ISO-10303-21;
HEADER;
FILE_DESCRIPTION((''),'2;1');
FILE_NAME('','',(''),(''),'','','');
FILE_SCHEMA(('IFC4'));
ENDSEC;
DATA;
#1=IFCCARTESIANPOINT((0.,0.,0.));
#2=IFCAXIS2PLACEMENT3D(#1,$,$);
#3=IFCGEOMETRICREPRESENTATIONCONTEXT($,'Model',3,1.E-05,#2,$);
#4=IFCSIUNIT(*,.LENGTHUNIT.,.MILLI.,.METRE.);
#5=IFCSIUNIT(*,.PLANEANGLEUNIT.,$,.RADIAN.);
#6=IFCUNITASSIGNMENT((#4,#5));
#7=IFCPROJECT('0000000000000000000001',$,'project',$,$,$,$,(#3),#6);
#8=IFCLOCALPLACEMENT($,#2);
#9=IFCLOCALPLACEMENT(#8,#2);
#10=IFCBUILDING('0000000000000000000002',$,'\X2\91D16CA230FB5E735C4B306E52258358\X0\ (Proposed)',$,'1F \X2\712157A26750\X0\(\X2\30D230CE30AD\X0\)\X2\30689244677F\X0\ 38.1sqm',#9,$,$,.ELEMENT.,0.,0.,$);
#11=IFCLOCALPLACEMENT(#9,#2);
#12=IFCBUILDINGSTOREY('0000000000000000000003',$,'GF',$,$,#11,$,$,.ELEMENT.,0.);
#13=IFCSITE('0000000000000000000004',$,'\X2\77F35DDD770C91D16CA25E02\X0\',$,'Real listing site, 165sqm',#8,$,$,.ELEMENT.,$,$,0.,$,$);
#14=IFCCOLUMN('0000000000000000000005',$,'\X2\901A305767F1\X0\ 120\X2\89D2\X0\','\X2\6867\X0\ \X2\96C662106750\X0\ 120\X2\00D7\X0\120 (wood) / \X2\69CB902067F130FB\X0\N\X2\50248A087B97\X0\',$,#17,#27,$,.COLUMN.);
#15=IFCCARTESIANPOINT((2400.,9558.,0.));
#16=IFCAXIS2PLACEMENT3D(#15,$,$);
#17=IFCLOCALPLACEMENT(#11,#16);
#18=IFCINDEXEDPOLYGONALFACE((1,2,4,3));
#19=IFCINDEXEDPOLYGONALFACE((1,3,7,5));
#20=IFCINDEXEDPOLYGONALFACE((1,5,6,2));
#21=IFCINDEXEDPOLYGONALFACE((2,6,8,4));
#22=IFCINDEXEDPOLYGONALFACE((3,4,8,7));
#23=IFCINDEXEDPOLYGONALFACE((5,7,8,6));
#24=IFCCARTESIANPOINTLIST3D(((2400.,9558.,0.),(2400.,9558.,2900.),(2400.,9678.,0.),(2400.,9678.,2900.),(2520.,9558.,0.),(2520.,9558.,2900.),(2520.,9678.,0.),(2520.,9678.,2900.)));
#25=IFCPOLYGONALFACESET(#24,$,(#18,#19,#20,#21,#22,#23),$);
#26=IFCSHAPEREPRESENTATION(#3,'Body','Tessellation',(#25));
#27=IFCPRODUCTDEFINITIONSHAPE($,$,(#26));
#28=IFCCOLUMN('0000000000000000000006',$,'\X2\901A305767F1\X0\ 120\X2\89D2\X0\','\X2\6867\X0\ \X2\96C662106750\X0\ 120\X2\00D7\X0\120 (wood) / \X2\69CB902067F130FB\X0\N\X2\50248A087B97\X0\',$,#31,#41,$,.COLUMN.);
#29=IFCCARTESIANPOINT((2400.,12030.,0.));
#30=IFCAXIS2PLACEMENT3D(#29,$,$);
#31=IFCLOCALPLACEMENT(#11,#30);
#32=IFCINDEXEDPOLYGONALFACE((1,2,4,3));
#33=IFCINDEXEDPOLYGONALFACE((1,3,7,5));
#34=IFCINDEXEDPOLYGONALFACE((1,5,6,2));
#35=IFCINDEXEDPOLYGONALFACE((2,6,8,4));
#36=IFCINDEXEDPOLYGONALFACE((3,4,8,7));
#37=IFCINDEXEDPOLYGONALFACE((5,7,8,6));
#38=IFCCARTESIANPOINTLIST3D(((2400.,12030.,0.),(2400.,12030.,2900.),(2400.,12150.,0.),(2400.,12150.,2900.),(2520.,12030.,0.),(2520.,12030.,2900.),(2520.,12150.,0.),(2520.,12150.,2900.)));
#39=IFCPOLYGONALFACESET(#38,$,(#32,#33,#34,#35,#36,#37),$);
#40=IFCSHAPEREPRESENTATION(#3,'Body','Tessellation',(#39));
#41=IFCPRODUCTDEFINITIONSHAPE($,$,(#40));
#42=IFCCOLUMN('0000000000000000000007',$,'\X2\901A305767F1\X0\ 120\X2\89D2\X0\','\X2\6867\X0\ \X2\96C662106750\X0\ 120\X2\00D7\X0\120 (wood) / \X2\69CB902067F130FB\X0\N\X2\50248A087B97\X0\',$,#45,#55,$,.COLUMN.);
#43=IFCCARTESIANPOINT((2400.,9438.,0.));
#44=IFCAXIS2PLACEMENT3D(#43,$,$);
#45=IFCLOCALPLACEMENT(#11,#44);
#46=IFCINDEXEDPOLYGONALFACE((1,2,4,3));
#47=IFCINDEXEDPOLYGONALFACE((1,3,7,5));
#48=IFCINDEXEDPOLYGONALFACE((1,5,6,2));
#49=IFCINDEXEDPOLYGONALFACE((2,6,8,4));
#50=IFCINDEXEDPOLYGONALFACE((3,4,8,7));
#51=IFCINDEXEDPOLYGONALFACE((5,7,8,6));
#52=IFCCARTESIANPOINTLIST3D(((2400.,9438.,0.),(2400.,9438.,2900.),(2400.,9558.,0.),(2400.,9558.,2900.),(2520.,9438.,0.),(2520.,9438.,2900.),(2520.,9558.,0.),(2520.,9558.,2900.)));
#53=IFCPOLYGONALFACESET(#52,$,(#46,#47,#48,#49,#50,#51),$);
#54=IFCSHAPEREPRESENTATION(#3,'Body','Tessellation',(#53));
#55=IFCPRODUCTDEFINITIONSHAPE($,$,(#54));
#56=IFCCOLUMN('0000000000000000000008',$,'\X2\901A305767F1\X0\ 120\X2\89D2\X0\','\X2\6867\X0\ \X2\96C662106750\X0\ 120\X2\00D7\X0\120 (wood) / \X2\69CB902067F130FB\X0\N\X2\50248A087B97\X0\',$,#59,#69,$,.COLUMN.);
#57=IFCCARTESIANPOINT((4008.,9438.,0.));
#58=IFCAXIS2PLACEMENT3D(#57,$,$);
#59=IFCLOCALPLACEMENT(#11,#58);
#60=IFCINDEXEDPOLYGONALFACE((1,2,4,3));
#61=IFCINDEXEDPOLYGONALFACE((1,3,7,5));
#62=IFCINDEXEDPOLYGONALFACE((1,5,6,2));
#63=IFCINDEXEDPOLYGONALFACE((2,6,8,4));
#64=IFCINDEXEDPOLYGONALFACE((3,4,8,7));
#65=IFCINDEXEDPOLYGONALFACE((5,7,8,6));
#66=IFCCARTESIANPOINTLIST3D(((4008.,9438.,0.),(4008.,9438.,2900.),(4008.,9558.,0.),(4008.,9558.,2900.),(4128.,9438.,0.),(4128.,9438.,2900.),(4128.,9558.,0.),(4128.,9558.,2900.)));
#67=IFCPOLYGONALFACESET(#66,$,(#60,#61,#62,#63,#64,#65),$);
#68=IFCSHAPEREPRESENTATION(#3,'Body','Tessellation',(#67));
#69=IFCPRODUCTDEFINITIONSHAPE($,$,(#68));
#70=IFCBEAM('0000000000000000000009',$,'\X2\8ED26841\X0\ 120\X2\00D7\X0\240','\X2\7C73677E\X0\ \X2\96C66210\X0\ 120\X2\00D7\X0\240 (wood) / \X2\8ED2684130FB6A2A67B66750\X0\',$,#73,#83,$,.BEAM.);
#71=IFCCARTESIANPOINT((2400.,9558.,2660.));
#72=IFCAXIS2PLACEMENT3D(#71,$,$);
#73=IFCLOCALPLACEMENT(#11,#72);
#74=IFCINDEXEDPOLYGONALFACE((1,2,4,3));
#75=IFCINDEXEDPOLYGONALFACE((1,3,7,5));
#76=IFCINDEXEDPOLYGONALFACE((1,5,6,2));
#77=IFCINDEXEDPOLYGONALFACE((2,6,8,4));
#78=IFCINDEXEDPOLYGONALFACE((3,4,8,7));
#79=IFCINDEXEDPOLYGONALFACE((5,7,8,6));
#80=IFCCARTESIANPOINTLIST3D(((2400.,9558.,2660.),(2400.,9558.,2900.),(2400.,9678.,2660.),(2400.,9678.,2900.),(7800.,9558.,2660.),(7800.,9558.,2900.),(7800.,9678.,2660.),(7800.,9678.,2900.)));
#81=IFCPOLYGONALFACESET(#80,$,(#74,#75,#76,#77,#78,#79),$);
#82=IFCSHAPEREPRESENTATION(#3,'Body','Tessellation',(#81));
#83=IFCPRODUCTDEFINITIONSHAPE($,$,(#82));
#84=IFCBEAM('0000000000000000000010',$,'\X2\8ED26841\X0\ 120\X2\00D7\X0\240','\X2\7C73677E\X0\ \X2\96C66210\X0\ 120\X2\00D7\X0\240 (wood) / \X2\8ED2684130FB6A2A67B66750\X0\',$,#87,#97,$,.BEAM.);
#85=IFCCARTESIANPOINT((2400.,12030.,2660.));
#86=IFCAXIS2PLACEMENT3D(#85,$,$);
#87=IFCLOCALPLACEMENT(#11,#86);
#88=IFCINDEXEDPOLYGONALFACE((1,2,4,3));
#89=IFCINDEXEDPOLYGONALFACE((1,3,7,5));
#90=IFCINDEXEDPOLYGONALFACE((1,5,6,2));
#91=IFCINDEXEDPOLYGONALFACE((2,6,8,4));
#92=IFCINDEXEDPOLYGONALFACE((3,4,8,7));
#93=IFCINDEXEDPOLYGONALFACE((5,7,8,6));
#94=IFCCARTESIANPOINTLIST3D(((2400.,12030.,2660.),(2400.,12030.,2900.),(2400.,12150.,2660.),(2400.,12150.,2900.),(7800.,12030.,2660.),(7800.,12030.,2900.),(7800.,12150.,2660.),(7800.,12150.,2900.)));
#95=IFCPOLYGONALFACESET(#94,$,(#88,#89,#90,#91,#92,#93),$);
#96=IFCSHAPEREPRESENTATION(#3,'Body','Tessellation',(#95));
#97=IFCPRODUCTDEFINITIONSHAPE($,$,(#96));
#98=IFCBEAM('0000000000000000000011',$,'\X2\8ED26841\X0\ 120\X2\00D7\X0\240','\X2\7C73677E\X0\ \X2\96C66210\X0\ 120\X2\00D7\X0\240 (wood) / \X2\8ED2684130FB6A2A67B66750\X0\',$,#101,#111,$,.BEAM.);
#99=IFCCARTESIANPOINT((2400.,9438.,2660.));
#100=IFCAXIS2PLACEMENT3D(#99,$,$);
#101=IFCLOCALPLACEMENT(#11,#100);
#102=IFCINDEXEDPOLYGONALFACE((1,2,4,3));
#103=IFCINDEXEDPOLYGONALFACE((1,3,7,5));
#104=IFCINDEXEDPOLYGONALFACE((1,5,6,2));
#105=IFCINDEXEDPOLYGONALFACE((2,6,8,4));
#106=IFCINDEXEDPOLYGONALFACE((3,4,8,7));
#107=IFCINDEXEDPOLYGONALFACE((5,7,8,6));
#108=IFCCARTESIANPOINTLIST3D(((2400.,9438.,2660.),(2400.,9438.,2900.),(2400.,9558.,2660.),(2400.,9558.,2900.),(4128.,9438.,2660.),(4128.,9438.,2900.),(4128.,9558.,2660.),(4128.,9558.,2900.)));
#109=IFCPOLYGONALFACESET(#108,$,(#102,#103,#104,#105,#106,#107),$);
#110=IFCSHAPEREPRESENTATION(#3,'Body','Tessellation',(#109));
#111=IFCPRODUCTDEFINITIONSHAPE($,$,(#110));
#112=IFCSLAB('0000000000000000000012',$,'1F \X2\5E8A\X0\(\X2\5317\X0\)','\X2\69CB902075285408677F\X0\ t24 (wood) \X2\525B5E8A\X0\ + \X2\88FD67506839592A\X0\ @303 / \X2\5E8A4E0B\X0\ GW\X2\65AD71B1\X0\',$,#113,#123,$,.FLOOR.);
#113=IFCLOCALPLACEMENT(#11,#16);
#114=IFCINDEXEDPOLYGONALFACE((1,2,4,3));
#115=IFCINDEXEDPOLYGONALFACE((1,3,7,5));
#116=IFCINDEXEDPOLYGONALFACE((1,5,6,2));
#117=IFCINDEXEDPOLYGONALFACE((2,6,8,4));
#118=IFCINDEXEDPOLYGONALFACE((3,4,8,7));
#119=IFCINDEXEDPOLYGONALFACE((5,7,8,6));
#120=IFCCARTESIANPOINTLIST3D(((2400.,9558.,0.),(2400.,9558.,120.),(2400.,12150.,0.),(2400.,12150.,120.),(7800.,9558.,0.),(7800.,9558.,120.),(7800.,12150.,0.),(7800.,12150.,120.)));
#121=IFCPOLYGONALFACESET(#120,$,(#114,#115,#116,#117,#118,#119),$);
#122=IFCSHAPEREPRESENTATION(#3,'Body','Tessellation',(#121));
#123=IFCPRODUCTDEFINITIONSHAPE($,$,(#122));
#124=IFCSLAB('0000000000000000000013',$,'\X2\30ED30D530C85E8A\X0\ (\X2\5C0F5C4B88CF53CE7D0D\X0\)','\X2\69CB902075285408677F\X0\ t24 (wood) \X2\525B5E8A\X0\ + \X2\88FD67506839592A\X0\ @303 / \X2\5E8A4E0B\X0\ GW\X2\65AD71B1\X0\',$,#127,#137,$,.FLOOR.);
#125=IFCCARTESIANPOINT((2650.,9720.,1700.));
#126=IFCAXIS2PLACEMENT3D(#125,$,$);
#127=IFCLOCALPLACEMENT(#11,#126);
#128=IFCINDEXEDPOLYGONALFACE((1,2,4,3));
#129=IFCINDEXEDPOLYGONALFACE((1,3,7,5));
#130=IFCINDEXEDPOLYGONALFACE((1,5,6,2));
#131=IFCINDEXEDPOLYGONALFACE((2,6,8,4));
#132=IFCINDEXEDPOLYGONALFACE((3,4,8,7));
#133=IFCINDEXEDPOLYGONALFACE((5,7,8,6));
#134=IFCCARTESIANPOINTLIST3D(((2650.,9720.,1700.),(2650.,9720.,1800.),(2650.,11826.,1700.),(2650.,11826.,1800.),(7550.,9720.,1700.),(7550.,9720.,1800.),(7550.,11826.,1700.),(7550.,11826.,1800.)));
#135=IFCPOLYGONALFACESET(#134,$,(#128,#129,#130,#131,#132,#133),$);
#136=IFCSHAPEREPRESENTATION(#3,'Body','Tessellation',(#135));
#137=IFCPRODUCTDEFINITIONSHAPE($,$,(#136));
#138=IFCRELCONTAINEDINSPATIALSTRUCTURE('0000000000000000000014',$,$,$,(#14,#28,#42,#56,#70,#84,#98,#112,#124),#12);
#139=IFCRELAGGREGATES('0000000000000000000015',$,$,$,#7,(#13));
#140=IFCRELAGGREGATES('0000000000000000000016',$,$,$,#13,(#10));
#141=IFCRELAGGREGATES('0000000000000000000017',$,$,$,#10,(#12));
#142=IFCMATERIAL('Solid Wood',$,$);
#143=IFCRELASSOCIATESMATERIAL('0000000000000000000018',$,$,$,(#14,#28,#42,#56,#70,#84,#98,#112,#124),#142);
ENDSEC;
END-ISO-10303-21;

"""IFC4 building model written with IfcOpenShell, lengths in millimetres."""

from ifc_helpers import new_model, si_unit, frame, frame_2d, origin, place, context, project, spatial, rectangle, extrude, material, element, save


model = new_model("IFC4")

# Units and contexts
model_context = context("Model", 3, precision=1e-05, world=origin())
ifc_project = project(units=[si_unit("LENGTHUNIT", "METRE", prefix="MILLI"), si_unit("PLANEANGLEUNIT", "RADIAN")], contexts=[model_context])

# Site, building, storey
site_placement = place(None, origin())
site = spatial("IfcSite", under=ifc_project, at=site_placement, Name="石川県金沢市", ObjectType="Real listing site, 165sqm", CompositionType="ELEMENT", RefElevation=0.0)
building_placement = place(site_placement, origin())
building = spatial("IfcBuilding", under=site, at=building_placement, Name="金沢・平屋の別荘 (Proposed)", ObjectType="1F 無垢材(ヒノキ)と鉄板 38.1sqm", CompositionType="ELEMENT", ElevationOfRefHeight=0.0, ElevationOfTerrain=0.0)
storey_placement = place(building_placement, origin())
storey = spatial("IfcBuildingStorey", under=building, at=storey_placement, Name="GF", CompositionType="ELEMENT", Elevation=0.0)

# Columns
ifc_material_1 = material(Name="Solid Wood")
column_1_placement = place(storey_placement, frame((2400.0, 9558.0, 0.0)))
element("IfcColumn", 1, at=column_1_placement, inside=storey, material=ifc_material_1, Name="通し柱 120角", Description="桧 集成材 120×120 (wood) / 構造柱・N値計算", PredefinedType="COLUMN", context=model_context, shape_type="SweptSolid", body=[
    extrude(rectangle(XDim=120.0, YDim=120.0, at=frame_2d((60.0, 60.0))), frame((2400.0, 9558.0, 0.0)), (0.0, 0.0, 1.0), 2900.0),
])
column_2_placement = place(storey_placement, frame((2400.0, 12030.0, 0.0)))
element("IfcColumn", 2, at=column_2_placement, inside=storey, material=ifc_material_1, Name="通し柱 120角", Description="桧 集成材 120×120 (wood) / 構造柱・N値計算", PredefinedType="COLUMN", context=model_context, shape_type="SweptSolid", body=[
    extrude(rectangle(XDim=120.0, YDim=120.0, at=frame_2d((60.0, 60.0))), frame((2400.0, 12030.0, 0.0)), (0.0, 0.0, 1.0), 2900.0),
])
column_3_placement = place(storey_placement, frame((2400.0, 9438.0, 0.0)))
element("IfcColumn", 3, at=column_3_placement, inside=storey, material=ifc_material_1, Name="通し柱 120角", Description="桧 集成材 120×120 (wood) / 構造柱・N値計算", PredefinedType="COLUMN", context=model_context, shape_type="SweptSolid", body=[
    extrude(rectangle(XDim=120.0, YDim=120.0, at=frame_2d((60.0, 60.0))), frame((2400.0, 9438.0, 0.0)), (0.0, 0.0, 1.0), 2900.0),
])
column_4_placement = place(storey_placement, frame((4008.0, 9438.0, 0.0)))
element("IfcColumn", 4, at=column_4_placement, inside=storey, material=ifc_material_1, Name="通し柱 120角", Description="桧 集成材 120×120 (wood) / 構造柱・N値計算", PredefinedType="COLUMN", context=model_context, shape_type="SweptSolid", body=[
    extrude(rectangle(XDim=120.0, YDim=120.0, at=frame_2d((60.0, 60.0))), frame((4008.0, 9438.0, 0.0)), (0.0, 0.0, 1.0), 2900.0),
])

# Beams
beam_1_placement = place(storey_placement, frame((2400.0, 9558.0, 2660.0)))
element("IfcBeam", 5, at=beam_1_placement, inside=storey, material=ifc_material_1, Name="軒桁 120×240", Description="米松 集成 120×240 (wood) / 軒桁・横架材", PredefinedType="BEAM", context=model_context, shape_type="SweptSolid", body=[
    extrude(rectangle(XDim=5400.0, YDim=120.0, at=frame_2d((2700.0, 60.0))), frame((2400.0, 9558.0, 2660.0)), (0.0, 0.0, 1.0), 240.0),
])
beam_2_placement = place(storey_placement, frame((2400.0, 12030.0, 2660.0)))
element("IfcBeam", 6, at=beam_2_placement, inside=storey, material=ifc_material_1, Name="軒桁 120×240", Description="米松 集成 120×240 (wood) / 軒桁・横架材", PredefinedType="BEAM", context=model_context, shape_type="SweptSolid", body=[
    extrude(rectangle(XDim=5400.0, YDim=120.0, at=frame_2d((2700.0, 60.0))), frame((2400.0, 12030.0, 2660.0)), (0.0, 0.0, 1.0), 240.0),
])
beam_3_placement = place(storey_placement, frame((2400.0, 9438.0, 2660.0)))
element("IfcBeam", 7, at=beam_3_placement, inside=storey, material=ifc_material_1, Name="軒桁 120×240", Description="米松 集成 120×240 (wood) / 軒桁・横架材", PredefinedType="BEAM", context=model_context, shape_type="SweptSolid", body=[
    extrude(rectangle(XDim=1728.0, YDim=120.0, at=frame_2d((864.0, 60.0))), frame((2400.0, 9438.0, 2660.0)), (0.0, 0.0, 1.0), 240.0),
])

# Slabs
slab_1_placement = place(storey_placement, frame((2400.0, 9558.0, 0.0)))
element("IfcSlab", 8, at=slab_1_placement, inside=storey, material=ifc_material_1, Name="1F 床(北)", Description="構造用合板 t24 (wood) 剛床 + 製材根太 @303 / 床下 GW断熱", PredefinedType="FLOOR", context=model_context, shape_type="SweptSolid", body=[
    extrude(rectangle(XDim=5400.0, YDim=2592.0, at=frame_2d((2700.0, 1296.0))), frame((2400.0, 9558.0, 0.0)), (0.0, 0.0, 1.0), 120.0),
])
slab_2_placement = place(storey_placement, frame((2650.0, 9720.0, 1700.0)))
element("IfcSlab", 9, at=slab_2_placement, inside=storey, material=ifc_material_1, Name="ロフト床 (小屋裏収納)", Description="構造用合板 t24 (wood) 剛床 + 製材根太 @303 / 床下 GW断熱", PredefinedType="FLOOR", context=model_context, shape_type="SweptSolid", body=[
    extrude(rectangle(XDim=4900.0, YDim=2106.0, at=frame_2d((2450.0, 1053.0))), frame((2650.0, 9720.0, 1700.0)), (0.0, 0.0, 1.0), 100.0),
])

save(model, "model.ifc")
